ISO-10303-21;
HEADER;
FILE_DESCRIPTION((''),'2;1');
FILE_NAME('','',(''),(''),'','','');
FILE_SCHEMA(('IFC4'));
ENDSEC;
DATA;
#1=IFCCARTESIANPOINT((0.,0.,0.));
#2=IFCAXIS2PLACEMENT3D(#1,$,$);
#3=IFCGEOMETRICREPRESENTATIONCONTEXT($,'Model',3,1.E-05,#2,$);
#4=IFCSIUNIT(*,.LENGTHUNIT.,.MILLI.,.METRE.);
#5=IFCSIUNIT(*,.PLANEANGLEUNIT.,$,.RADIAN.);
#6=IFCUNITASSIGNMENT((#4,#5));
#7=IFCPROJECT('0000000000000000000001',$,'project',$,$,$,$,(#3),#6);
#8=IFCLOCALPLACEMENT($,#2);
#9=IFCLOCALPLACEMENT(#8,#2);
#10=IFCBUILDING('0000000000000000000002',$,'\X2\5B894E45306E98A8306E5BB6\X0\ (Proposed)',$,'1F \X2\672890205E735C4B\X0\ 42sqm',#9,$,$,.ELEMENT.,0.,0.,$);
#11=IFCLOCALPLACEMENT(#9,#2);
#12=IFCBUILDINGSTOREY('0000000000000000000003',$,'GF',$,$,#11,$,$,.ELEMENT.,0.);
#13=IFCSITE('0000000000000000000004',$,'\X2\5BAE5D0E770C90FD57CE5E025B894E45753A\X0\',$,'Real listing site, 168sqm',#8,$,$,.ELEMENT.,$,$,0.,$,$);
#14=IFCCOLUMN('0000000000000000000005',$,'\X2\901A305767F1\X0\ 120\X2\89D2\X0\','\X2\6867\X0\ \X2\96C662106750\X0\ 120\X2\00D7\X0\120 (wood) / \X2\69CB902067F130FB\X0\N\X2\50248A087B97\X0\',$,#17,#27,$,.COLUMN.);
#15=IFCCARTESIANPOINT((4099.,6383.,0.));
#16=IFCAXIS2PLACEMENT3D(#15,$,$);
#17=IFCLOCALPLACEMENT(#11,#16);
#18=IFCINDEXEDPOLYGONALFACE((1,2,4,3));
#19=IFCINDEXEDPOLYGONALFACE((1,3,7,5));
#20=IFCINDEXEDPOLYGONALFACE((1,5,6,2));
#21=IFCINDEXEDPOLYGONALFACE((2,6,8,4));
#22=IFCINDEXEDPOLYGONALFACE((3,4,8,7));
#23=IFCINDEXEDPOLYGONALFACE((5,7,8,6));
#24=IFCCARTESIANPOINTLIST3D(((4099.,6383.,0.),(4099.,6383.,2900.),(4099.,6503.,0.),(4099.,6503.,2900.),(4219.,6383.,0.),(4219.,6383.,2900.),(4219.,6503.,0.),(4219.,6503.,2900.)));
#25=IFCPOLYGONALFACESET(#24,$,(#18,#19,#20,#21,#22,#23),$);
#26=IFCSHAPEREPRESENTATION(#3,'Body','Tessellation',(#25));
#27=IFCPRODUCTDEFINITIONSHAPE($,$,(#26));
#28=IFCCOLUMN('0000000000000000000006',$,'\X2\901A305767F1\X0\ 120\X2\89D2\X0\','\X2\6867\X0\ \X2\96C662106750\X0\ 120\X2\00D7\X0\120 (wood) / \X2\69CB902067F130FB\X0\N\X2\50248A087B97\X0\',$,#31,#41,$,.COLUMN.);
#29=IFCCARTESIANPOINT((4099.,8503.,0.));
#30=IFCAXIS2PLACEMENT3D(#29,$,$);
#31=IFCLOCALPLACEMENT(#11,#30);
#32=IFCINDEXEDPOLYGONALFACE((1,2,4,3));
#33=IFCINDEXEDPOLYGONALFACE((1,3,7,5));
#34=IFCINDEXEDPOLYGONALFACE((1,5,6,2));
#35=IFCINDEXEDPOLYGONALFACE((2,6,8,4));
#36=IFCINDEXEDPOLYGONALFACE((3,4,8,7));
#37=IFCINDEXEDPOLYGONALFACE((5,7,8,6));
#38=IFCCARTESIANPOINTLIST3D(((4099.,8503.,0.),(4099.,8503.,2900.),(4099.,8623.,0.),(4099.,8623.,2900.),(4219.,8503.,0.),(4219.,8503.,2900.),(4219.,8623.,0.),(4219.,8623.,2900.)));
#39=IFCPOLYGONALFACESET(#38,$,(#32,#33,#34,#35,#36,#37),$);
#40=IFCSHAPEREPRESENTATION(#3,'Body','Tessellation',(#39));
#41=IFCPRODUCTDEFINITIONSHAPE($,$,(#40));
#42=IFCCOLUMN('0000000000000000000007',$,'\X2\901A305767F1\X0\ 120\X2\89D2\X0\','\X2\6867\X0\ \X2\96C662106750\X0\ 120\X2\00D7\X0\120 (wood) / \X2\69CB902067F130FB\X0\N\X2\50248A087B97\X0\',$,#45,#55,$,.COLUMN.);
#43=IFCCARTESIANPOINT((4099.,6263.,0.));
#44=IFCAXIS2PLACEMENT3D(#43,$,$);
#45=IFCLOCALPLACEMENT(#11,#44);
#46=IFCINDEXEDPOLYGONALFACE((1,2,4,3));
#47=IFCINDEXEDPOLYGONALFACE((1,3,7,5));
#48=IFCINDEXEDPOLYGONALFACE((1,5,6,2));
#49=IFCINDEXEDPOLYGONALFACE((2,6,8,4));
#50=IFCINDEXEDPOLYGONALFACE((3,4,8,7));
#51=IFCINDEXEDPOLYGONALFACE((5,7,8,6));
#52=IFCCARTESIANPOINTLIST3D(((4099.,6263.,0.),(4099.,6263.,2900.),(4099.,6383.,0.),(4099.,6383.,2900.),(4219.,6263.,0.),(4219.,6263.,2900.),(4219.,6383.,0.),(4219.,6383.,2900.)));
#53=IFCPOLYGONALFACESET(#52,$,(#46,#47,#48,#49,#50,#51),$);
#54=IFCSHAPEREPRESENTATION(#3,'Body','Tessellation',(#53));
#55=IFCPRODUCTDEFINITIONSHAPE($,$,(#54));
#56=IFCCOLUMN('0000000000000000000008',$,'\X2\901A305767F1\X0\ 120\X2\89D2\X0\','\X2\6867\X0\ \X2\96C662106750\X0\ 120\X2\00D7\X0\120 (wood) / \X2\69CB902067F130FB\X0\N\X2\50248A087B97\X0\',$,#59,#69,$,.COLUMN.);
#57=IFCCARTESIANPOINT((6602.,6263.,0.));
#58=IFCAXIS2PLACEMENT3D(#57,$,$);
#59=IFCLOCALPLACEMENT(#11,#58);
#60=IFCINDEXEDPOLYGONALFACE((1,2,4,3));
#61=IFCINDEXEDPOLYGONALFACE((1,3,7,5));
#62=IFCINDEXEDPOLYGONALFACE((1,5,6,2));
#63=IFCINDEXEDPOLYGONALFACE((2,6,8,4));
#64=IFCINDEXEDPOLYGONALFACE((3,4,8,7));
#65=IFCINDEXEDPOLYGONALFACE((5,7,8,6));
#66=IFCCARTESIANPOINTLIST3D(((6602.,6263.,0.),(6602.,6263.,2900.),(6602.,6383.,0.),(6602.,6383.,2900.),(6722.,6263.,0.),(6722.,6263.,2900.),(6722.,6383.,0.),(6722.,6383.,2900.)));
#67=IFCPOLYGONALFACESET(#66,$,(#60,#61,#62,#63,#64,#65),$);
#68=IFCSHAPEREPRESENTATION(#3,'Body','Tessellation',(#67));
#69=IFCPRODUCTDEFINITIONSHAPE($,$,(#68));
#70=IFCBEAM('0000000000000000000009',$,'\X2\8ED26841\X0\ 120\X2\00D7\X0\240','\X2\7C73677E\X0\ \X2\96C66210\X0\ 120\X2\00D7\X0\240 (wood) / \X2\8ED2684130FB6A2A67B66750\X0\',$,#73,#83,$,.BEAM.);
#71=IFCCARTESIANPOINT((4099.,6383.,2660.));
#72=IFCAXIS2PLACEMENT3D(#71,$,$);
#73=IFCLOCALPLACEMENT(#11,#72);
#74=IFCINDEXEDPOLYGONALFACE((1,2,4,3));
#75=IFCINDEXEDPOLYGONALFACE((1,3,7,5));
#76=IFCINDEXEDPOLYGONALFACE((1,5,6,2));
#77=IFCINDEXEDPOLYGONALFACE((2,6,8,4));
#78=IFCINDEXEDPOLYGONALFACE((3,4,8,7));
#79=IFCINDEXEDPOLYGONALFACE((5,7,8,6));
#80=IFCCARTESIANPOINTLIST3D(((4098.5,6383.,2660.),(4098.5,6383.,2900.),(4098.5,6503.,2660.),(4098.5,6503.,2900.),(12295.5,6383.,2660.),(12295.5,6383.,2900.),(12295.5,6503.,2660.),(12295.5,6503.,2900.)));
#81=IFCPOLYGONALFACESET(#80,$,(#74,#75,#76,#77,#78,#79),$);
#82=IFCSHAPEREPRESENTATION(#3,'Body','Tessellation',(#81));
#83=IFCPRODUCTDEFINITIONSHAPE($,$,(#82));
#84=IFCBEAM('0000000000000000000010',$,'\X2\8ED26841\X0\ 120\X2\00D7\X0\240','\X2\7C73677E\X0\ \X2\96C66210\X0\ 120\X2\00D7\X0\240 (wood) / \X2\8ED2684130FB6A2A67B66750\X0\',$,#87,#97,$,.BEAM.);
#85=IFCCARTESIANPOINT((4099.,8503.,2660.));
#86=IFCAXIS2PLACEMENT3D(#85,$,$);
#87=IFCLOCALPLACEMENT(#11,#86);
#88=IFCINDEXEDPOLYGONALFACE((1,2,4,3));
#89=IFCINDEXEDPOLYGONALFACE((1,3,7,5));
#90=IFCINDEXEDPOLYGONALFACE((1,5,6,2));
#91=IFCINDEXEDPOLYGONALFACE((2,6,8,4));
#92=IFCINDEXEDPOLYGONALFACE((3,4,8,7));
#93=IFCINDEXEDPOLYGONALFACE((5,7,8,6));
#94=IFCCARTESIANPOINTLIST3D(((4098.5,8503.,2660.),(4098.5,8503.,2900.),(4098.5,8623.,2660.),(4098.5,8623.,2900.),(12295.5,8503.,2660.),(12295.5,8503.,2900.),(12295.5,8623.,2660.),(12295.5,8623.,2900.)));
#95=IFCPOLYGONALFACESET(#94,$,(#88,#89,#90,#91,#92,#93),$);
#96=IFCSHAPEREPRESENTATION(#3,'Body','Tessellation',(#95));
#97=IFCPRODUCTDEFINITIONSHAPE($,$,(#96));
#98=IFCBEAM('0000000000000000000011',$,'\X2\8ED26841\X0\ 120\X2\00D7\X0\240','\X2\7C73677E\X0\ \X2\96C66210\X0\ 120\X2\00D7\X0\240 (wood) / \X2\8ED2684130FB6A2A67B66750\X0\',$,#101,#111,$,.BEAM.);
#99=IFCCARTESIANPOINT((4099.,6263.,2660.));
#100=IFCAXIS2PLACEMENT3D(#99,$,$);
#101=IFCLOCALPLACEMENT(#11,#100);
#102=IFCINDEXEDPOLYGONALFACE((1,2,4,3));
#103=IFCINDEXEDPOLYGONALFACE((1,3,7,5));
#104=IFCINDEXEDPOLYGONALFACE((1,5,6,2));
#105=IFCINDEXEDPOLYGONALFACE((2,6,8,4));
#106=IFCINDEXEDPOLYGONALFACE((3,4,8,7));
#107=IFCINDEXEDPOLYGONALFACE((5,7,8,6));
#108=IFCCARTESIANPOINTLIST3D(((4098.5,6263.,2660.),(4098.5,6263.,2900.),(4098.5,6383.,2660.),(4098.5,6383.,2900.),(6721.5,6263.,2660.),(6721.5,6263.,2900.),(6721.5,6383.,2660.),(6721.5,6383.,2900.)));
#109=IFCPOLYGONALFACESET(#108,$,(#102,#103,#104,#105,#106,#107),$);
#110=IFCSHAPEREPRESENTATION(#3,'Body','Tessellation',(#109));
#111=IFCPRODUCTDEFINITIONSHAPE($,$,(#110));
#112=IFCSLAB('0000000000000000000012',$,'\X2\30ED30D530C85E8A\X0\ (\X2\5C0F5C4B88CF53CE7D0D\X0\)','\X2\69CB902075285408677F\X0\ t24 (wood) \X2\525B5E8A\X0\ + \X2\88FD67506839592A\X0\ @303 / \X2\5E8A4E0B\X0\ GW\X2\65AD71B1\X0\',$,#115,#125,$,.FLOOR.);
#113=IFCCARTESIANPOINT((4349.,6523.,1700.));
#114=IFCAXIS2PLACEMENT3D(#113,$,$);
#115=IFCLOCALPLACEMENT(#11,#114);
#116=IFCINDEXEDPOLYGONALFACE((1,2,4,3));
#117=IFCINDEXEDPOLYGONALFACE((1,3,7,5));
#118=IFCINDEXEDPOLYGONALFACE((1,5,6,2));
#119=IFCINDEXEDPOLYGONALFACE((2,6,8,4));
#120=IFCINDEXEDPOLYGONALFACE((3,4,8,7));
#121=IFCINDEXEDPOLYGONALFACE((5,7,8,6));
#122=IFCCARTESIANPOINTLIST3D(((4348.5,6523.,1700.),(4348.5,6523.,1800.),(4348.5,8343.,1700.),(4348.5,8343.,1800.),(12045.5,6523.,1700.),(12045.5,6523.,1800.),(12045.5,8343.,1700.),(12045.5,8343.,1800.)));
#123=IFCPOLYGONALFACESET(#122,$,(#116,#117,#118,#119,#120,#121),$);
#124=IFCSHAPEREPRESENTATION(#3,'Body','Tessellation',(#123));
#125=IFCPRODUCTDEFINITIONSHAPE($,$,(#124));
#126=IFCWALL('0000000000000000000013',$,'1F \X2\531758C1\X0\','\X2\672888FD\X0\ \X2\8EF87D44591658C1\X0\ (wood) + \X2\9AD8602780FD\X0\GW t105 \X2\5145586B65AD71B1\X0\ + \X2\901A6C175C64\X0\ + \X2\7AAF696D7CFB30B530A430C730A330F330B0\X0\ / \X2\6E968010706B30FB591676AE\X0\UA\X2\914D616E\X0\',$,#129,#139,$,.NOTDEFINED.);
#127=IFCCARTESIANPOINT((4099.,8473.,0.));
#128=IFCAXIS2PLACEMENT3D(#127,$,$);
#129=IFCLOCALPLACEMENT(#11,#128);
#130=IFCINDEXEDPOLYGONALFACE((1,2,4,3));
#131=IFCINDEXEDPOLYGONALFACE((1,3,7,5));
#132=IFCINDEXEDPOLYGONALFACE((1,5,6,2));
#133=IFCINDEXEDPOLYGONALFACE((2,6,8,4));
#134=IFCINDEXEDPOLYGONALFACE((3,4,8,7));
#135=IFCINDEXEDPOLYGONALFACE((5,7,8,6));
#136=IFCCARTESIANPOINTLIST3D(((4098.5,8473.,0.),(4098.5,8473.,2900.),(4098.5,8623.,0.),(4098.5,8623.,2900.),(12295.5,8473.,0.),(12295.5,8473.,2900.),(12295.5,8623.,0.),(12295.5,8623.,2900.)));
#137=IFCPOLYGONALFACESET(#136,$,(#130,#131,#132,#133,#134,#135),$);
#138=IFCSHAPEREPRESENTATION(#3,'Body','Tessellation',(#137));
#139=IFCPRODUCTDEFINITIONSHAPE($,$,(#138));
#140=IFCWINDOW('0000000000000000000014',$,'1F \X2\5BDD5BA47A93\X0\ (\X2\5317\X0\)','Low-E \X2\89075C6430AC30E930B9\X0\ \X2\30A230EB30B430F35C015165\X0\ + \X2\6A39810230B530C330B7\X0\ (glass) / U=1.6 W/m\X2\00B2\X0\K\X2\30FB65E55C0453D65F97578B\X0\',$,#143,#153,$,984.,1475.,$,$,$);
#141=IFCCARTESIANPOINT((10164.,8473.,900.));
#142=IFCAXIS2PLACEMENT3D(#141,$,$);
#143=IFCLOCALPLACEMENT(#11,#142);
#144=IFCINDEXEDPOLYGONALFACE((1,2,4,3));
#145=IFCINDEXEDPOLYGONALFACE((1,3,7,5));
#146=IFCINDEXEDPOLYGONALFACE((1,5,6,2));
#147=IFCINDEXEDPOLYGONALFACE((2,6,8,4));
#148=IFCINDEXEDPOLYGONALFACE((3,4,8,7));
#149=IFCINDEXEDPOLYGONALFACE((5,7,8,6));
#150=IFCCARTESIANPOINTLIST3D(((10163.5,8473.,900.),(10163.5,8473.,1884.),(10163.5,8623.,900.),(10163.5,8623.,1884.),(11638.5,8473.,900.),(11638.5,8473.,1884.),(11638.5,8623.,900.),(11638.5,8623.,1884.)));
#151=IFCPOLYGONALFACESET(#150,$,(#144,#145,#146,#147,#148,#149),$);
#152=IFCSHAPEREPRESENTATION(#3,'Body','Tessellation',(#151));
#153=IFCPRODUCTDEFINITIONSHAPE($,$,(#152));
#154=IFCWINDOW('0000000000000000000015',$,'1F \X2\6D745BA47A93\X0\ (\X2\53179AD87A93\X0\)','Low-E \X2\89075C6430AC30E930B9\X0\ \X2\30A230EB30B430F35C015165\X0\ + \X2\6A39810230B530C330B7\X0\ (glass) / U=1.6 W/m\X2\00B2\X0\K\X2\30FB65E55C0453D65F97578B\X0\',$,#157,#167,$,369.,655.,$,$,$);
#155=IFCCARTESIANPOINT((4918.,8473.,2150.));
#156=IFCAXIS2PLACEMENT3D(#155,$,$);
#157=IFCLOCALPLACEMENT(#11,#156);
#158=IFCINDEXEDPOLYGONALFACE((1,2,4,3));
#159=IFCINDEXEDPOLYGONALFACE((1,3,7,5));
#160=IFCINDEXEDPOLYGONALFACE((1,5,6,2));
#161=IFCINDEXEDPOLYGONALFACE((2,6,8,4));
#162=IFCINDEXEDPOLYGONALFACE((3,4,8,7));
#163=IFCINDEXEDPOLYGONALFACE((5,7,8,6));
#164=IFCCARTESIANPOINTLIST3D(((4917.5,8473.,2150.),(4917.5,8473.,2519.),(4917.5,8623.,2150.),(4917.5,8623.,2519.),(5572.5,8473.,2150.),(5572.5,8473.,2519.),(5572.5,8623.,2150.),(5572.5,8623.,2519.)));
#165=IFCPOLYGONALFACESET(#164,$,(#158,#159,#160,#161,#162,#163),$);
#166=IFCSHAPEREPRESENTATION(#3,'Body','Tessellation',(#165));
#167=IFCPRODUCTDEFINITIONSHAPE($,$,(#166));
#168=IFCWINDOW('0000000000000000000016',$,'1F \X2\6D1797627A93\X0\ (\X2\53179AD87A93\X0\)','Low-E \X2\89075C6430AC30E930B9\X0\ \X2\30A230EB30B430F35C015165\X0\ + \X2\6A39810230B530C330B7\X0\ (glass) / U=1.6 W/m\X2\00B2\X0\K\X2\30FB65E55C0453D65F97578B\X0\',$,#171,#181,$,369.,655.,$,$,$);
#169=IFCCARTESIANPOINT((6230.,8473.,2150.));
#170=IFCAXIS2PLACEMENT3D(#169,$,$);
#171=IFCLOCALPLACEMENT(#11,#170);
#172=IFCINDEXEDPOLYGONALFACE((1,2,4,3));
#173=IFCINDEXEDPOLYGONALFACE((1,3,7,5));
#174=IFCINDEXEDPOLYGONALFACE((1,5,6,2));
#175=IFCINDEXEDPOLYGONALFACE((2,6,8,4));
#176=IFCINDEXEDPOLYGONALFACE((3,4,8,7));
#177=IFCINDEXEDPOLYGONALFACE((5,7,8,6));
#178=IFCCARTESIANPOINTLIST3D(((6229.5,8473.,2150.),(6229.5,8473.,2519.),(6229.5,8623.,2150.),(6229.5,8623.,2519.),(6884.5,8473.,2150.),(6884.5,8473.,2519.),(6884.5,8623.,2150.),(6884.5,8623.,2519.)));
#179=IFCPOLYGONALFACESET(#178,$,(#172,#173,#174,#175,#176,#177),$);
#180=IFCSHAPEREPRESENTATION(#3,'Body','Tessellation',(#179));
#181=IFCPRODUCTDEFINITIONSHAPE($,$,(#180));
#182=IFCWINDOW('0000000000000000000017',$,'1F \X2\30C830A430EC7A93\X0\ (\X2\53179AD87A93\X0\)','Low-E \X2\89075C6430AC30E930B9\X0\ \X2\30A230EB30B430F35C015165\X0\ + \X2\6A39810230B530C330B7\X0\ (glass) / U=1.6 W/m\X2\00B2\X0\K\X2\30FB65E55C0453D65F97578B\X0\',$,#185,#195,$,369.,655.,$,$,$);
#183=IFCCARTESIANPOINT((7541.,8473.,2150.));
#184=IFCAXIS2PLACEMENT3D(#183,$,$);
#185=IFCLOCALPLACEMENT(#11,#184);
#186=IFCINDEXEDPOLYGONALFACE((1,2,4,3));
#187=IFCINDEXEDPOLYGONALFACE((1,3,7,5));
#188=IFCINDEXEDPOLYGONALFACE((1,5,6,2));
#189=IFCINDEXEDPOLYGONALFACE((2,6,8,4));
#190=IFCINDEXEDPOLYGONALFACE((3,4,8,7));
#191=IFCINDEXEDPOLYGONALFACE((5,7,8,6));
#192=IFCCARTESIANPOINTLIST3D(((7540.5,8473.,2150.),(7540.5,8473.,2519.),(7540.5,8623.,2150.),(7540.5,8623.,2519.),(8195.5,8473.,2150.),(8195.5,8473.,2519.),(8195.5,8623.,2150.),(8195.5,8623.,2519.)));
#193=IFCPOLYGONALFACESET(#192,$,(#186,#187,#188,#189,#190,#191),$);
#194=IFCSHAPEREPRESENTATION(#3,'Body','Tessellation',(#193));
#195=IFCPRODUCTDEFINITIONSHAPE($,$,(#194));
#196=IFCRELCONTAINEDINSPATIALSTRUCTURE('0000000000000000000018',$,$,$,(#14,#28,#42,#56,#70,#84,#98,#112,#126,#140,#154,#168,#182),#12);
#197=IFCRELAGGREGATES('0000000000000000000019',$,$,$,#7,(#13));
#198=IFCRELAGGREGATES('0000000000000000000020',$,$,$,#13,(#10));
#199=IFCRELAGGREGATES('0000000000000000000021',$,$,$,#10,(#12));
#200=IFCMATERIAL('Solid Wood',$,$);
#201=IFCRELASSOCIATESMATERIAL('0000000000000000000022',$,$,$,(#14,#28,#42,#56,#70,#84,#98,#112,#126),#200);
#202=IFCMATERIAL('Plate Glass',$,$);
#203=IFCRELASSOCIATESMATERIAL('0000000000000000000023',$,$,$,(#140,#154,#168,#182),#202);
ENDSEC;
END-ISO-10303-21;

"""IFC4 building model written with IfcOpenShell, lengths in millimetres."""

from ifc_helpers import new_model, si_unit, frame, frame_2d, origin, place, context, project, spatial, rectangle, extrude, material, element, fill, save


model = new_model("IFC4")

# Units and contexts
model_context = context("Model", 3, precision=1e-05, world=origin())
ifc_project = project(units=[si_unit("LENGTHUNIT", "METRE", prefix="MILLI"), si_unit("PLANEANGLEUNIT", "RADIAN")], contexts=[model_context])

# Site, building, storey
site_placement = place(None, origin())
site = spatial("IfcSite", under=ifc_project, at=site_placement, Name="宮崎県都城市安久町", ObjectType="Real listing site, 168sqm", CompositionType="ELEMENT", RefElevation=0.0)
building_placement = place(site_placement, origin())
building = spatial("IfcBuilding", under=site, at=building_placement, Name="安久の風の家 (Proposed)", ObjectType="1F 木造平屋 42sqm", CompositionType="ELEMENT", ElevationOfRefHeight=0.0, ElevationOfTerrain=0.0)
storey_placement = place(building_placement, origin())
storey = spatial("IfcBuildingStorey", under=building, at=storey_placement, Name="GF", CompositionType="ELEMENT", Elevation=0.0)

# Columns
ifc_material_1 = material(Name="Solid Wood")
column_1_placement = place(storey_placement, frame((4099.0, 6383.0, 0.0)))
element("IfcColumn", 1, at=column_1_placement, inside=storey, material=ifc_material_1, Name="通し柱 120角", Description="桧 集成材 120×120 (wood) / 構造柱・N値計算", PredefinedType="COLUMN", context=model_context, shape_type="SweptSolid", body=[
    extrude(rectangle(XDim=120.0, YDim=120.0, at=frame_2d((60.0, 60.0))), frame((4099.0, 6383.0, 0.0)), (0.0, 0.0, 1.0), 2900.0),
])
column_2_placement = place(storey_placement, frame((4099.0, 8503.0, 0.0)))
element("IfcColumn", 2, at=column_2_placement, inside=storey, material=ifc_material_1, Name="通し柱 120角", Description="桧 集成材 120×120 (wood) / 構造柱・N値計算", PredefinedType="COLUMN", context=model_context, shape_type="SweptSolid", body=[
    extrude(rectangle(XDim=120.0, YDim=120.0, at=frame_2d((60.0, 60.0))), frame((4099.0, 8503.0, 0.0)), (0.0, 0.0, 1.0), 2900.0),
])
column_3_placement = place(storey_placement, frame((4099.0, 6263.0, 0.0)))
element("IfcColumn", 3, at=column_3_placement, inside=storey, material=ifc_material_1, Name="通し柱 120角", Description="桧 集成材 120×120 (wood) / 構造柱・N値計算", PredefinedType="COLUMN", context=model_context, shape_type="SweptSolid", body=[
    extrude(rectangle(XDim=120.0, YDim=120.0, at=frame_2d((60.0, 60.0))), frame((4099.0, 6263.0, 0.0)), (0.0, 0.0, 1.0), 2900.0),
])
column_4_placement = place(storey_placement, frame((6602.0, 6263.0, 0.0)))
element("IfcColumn", 4, at=column_4_placement, inside=storey, material=ifc_material_1, Name="通し柱 120角", Description="桧 集成材 120×120 (wood) / 構造柱・N値計算", PredefinedType="COLUMN", context=model_context, shape_type="SweptSolid", body=[
    extrude(rectangle(XDim=120.0, YDim=120.0, at=frame_2d((60.0, 60.0))), frame((6602.0, 6263.0, 0.0)), (0.0, 0.0, 1.0), 2900.0),
])

# Beams
beam_1_placement = place(storey_placement, frame((4099.0, 6383.0, 2660.0)))
element("IfcBeam", 5, at=beam_1_placement, inside=storey, material=ifc_material_1, Name="軒桁 120×240", Description="米松 集成 120×240 (wood) / 軒桁・横架材", PredefinedType="BEAM", context=model_context, shape_type="SweptSolid", body=[
    extrude(rectangle(XDim=8197.0, YDim=120.0, at=frame_2d((4098.0, 60.0))), frame((4099.0, 6383.0, 2660.0)), (0.0, 0.0, 1.0), 240.0),
])
beam_2_placement = place(storey_placement, frame((4099.0, 8503.0, 2660.0)))
element("IfcBeam", 6, at=beam_2_placement, inside=storey, material=ifc_material_1, Name="軒桁 120×240", Description="米松 集成 120×240 (wood) / 軒桁・横架材", PredefinedType="BEAM", context=model_context, shape_type="SweptSolid", body=[
    extrude(rectangle(XDim=8197.0, YDim=120.0, at=frame_2d((4098.0, 60.0))), frame((4099.0, 8503.0, 2660.0)), (0.0, 0.0, 1.0), 240.0),
])
beam_3_placement = place(storey_placement, frame((4099.0, 6263.0, 2660.0)))
element("IfcBeam", 7, at=beam_3_placement, inside=storey, material=ifc_material_1, Name="軒桁 120×240", Description="米松 集成 120×240 (wood) / 軒桁・横架材", PredefinedType="BEAM", context=model_context, shape_type="SweptSolid", body=[
    extrude(rectangle(XDim=2623.0, YDim=120.0, at=frame_2d((1311.0, 60.0))), frame((4099.0, 6263.0, 2660.0)), (0.0, 0.0, 1.0), 240.0),
])

# Slab
slab_1_placement = place(storey_placement, frame((4349.0, 6523.0, 1700.0)))
element("IfcSlab", 8, at=slab_1_placement, inside=storey, material=ifc_material_1, Name="ロフト床 (小屋裏収納)", Description="構造用合板 t24 (wood) 剛床 + 製材根太 @303 / 床下 GW断熱", PredefinedType="FLOOR", context=model_context, shape_type="SweptSolid", body=[
    extrude(rectangle(XDim=7697.0, YDim=1820.0, at=frame_2d((3848.0, 910.0))), frame((4349.0, 6523.0, 1700.0)), (0.0, 0.0, 1.0), 100.0),
])

# Wall, openings, windows
wall_1_placement = place(storey_placement, frame((4099.0, 8473.0, 0.0)))
wall_1 = element("IfcWall", 9, at=wall_1_placement, inside=storey, material=ifc_material_1, Name="1F 北壁", Description="木製 軸組外壁 (wood) + 高性能GW t105 充填断熱 + 通気層 + 窯業系サイディング / 準耐火・外皮UA配慮", PredefinedType="NOTDEFINED", context=model_context, shape_type="SweptSolid", body=[
    extrude(rectangle(XDim=8197.0, YDim=150.0, at=frame_2d((4098.0, 75.0))), frame((4099.0, 8473.0, 0.0)), (0.0, 0.0, 1.0), 2900.0),
])
opening_1_placement = place(storey_placement, frame((10164.0, 8473.0, 900.0)))
opening_1 = element("IfcOpeningElement", 10, at=opening_1_placement, cuts=wall_1, PredefinedType="NOTDEFINED", context=model_context, shape_type="SweptSolid", body=[
    extrude(rectangle(XDim=1475.0, YDim=150.0, at=frame_2d((737.0, 75.0))), frame((10164.0, 8473.0, 900.0)), (0.0, 0.0, 1.0), 984.0),
])
opening_2_placement = place(storey_placement, frame((4918.0, 8473.0, 2150.0)))
opening_2 = element("IfcOpeningElement", 11, at=opening_2_placement, cuts=wall_1, PredefinedType="NOTDEFINED", context=model_context, shape_type="SweptSolid", body=[
    extrude(rectangle(XDim=655.0, YDim=150.0, at=frame_2d((327.0, 75.0))), frame((4918.0, 8473.0, 2150.0)), (0.0, 0.0, 1.0), 369.0),
])
opening_3_placement = place(storey_placement, frame((6230.0, 8473.0, 2150.0)))
opening_3 = element("IfcOpeningElement", 12, at=opening_3_placement, cuts=wall_1, PredefinedType="NOTDEFINED", context=model_context, shape_type="SweptSolid", body=[
    extrude(rectangle(XDim=655.0, YDim=150.0, at=frame_2d((327.0, 75.0))), frame((6230.0, 8473.0, 2150.0)), (0.0, 0.0, 1.0), 369.0),
])
opening_4_placement = place(storey_placement, frame((7541.0, 8473.0, 2150.0)))
opening_4 = element("IfcOpeningElement", 13, at=opening_4_placement, cuts=wall_1, PredefinedType="NOTDEFINED", context=model_context, shape_type="SweptSolid", body=[
    extrude(rectangle(XDim=655.0, YDim=150.0, at=frame_2d((327.0, 75.0))), frame((7541.0, 8473.0, 2150.0)), (0.0, 0.0, 1.0), 369.0),
])
ifc_material_2 = material(Name="Plate Glass")
window_1_placement = place(storey_placement, frame((10164.0, 8473.0, 900.0)))
window_1 = element("IfcWindow", 14, at=window_1_placement, inside=storey, material=ifc_material_2, Name="1F 寝室窓 (北)", Description="Low-E 複層ガラス アルゴン封入 + 樹脂サッシ (glass) / U=1.6 W/m²K・日射取得型", OverallHeight=984.0, OverallWidth=1475.0, context=model_context, shape_type="SweptSolid", body=[
    extrude(rectangle(XDim=1475.0, YDim=150.0, at=frame_2d((737.0, 75.0))), frame((10164.0, 8473.0, 900.0)), (0.0, 0.0, 1.0), 984.0),
])
fill(opening_1, window_1)
window_2_placement = place(storey_placement, frame((4918.0, 8473.0, 2150.0)))
window_2 = element("IfcWindow", 15, at=window_2_placement, inside=storey, material=ifc_material_2, Name="1F 浴室窓 (北高窓)", Description="Low-E 複層ガラス アルゴン封入 + 樹脂サッシ (glass) / U=1.6 W/m²K・日射取得型", OverallHeight=369.0, OverallWidth=655.0, context=model_context, shape_type="SweptSolid", body=[
    extrude(rectangle(XDim=655.0, YDim=150.0, at=frame_2d((327.0, 75.0))), frame((4918.0, 8473.0, 2150.0)), (0.0, 0.0, 1.0), 369.0),
])
fill(opening_2, window_2)
window_3_placement = place(storey_placement, frame((6230.0, 8473.0, 2150.0)))
window_3 = element("IfcWindow", 16, at=window_3_placement, inside=storey, material=ifc_material_2, Name="1F 洗面窓 (北高窓)", Description="Low-E 複層ガラス アルゴン封入 + 樹脂サッシ (glass) / U=1.6 W/m²K・日射取得型", OverallHeight=369.0, OverallWidth=655.0, context=model_context, shape_type="SweptSolid", body=[
    extrude(rectangle(XDim=655.0, YDim=150.0, at=frame_2d((327.0, 75.0))), frame((6230.0, 8473.0, 2150.0)), (0.0, 0.0, 1.0), 369.0),
])
fill(opening_3, window_3)
window_4_placement = place(storey_placement, frame((7541.0, 8473.0, 2150.0)))
window_4 = element("IfcWindow", 17, at=window_4_placement, inside=storey, material=ifc_material_2, Name="1F トイレ窓 (北高窓)", Description="Low-E 複層ガラス アルゴン封入 + 樹脂サッシ (glass) / U=1.6 W/m²K・日射取得型", OverallHeight=369.0, OverallWidth=655.0, context=model_context, shape_type="SweptSolid", body=[
    extrude(rectangle(XDim=655.0, YDim=150.0, at=frame_2d((327.0, 75.0))), frame((7541.0, 8473.0, 2150.0)), (0.0, 0.0, 1.0), 369.0),
])
fill(opening_4, window_4)

save(model, "model.ifc")
